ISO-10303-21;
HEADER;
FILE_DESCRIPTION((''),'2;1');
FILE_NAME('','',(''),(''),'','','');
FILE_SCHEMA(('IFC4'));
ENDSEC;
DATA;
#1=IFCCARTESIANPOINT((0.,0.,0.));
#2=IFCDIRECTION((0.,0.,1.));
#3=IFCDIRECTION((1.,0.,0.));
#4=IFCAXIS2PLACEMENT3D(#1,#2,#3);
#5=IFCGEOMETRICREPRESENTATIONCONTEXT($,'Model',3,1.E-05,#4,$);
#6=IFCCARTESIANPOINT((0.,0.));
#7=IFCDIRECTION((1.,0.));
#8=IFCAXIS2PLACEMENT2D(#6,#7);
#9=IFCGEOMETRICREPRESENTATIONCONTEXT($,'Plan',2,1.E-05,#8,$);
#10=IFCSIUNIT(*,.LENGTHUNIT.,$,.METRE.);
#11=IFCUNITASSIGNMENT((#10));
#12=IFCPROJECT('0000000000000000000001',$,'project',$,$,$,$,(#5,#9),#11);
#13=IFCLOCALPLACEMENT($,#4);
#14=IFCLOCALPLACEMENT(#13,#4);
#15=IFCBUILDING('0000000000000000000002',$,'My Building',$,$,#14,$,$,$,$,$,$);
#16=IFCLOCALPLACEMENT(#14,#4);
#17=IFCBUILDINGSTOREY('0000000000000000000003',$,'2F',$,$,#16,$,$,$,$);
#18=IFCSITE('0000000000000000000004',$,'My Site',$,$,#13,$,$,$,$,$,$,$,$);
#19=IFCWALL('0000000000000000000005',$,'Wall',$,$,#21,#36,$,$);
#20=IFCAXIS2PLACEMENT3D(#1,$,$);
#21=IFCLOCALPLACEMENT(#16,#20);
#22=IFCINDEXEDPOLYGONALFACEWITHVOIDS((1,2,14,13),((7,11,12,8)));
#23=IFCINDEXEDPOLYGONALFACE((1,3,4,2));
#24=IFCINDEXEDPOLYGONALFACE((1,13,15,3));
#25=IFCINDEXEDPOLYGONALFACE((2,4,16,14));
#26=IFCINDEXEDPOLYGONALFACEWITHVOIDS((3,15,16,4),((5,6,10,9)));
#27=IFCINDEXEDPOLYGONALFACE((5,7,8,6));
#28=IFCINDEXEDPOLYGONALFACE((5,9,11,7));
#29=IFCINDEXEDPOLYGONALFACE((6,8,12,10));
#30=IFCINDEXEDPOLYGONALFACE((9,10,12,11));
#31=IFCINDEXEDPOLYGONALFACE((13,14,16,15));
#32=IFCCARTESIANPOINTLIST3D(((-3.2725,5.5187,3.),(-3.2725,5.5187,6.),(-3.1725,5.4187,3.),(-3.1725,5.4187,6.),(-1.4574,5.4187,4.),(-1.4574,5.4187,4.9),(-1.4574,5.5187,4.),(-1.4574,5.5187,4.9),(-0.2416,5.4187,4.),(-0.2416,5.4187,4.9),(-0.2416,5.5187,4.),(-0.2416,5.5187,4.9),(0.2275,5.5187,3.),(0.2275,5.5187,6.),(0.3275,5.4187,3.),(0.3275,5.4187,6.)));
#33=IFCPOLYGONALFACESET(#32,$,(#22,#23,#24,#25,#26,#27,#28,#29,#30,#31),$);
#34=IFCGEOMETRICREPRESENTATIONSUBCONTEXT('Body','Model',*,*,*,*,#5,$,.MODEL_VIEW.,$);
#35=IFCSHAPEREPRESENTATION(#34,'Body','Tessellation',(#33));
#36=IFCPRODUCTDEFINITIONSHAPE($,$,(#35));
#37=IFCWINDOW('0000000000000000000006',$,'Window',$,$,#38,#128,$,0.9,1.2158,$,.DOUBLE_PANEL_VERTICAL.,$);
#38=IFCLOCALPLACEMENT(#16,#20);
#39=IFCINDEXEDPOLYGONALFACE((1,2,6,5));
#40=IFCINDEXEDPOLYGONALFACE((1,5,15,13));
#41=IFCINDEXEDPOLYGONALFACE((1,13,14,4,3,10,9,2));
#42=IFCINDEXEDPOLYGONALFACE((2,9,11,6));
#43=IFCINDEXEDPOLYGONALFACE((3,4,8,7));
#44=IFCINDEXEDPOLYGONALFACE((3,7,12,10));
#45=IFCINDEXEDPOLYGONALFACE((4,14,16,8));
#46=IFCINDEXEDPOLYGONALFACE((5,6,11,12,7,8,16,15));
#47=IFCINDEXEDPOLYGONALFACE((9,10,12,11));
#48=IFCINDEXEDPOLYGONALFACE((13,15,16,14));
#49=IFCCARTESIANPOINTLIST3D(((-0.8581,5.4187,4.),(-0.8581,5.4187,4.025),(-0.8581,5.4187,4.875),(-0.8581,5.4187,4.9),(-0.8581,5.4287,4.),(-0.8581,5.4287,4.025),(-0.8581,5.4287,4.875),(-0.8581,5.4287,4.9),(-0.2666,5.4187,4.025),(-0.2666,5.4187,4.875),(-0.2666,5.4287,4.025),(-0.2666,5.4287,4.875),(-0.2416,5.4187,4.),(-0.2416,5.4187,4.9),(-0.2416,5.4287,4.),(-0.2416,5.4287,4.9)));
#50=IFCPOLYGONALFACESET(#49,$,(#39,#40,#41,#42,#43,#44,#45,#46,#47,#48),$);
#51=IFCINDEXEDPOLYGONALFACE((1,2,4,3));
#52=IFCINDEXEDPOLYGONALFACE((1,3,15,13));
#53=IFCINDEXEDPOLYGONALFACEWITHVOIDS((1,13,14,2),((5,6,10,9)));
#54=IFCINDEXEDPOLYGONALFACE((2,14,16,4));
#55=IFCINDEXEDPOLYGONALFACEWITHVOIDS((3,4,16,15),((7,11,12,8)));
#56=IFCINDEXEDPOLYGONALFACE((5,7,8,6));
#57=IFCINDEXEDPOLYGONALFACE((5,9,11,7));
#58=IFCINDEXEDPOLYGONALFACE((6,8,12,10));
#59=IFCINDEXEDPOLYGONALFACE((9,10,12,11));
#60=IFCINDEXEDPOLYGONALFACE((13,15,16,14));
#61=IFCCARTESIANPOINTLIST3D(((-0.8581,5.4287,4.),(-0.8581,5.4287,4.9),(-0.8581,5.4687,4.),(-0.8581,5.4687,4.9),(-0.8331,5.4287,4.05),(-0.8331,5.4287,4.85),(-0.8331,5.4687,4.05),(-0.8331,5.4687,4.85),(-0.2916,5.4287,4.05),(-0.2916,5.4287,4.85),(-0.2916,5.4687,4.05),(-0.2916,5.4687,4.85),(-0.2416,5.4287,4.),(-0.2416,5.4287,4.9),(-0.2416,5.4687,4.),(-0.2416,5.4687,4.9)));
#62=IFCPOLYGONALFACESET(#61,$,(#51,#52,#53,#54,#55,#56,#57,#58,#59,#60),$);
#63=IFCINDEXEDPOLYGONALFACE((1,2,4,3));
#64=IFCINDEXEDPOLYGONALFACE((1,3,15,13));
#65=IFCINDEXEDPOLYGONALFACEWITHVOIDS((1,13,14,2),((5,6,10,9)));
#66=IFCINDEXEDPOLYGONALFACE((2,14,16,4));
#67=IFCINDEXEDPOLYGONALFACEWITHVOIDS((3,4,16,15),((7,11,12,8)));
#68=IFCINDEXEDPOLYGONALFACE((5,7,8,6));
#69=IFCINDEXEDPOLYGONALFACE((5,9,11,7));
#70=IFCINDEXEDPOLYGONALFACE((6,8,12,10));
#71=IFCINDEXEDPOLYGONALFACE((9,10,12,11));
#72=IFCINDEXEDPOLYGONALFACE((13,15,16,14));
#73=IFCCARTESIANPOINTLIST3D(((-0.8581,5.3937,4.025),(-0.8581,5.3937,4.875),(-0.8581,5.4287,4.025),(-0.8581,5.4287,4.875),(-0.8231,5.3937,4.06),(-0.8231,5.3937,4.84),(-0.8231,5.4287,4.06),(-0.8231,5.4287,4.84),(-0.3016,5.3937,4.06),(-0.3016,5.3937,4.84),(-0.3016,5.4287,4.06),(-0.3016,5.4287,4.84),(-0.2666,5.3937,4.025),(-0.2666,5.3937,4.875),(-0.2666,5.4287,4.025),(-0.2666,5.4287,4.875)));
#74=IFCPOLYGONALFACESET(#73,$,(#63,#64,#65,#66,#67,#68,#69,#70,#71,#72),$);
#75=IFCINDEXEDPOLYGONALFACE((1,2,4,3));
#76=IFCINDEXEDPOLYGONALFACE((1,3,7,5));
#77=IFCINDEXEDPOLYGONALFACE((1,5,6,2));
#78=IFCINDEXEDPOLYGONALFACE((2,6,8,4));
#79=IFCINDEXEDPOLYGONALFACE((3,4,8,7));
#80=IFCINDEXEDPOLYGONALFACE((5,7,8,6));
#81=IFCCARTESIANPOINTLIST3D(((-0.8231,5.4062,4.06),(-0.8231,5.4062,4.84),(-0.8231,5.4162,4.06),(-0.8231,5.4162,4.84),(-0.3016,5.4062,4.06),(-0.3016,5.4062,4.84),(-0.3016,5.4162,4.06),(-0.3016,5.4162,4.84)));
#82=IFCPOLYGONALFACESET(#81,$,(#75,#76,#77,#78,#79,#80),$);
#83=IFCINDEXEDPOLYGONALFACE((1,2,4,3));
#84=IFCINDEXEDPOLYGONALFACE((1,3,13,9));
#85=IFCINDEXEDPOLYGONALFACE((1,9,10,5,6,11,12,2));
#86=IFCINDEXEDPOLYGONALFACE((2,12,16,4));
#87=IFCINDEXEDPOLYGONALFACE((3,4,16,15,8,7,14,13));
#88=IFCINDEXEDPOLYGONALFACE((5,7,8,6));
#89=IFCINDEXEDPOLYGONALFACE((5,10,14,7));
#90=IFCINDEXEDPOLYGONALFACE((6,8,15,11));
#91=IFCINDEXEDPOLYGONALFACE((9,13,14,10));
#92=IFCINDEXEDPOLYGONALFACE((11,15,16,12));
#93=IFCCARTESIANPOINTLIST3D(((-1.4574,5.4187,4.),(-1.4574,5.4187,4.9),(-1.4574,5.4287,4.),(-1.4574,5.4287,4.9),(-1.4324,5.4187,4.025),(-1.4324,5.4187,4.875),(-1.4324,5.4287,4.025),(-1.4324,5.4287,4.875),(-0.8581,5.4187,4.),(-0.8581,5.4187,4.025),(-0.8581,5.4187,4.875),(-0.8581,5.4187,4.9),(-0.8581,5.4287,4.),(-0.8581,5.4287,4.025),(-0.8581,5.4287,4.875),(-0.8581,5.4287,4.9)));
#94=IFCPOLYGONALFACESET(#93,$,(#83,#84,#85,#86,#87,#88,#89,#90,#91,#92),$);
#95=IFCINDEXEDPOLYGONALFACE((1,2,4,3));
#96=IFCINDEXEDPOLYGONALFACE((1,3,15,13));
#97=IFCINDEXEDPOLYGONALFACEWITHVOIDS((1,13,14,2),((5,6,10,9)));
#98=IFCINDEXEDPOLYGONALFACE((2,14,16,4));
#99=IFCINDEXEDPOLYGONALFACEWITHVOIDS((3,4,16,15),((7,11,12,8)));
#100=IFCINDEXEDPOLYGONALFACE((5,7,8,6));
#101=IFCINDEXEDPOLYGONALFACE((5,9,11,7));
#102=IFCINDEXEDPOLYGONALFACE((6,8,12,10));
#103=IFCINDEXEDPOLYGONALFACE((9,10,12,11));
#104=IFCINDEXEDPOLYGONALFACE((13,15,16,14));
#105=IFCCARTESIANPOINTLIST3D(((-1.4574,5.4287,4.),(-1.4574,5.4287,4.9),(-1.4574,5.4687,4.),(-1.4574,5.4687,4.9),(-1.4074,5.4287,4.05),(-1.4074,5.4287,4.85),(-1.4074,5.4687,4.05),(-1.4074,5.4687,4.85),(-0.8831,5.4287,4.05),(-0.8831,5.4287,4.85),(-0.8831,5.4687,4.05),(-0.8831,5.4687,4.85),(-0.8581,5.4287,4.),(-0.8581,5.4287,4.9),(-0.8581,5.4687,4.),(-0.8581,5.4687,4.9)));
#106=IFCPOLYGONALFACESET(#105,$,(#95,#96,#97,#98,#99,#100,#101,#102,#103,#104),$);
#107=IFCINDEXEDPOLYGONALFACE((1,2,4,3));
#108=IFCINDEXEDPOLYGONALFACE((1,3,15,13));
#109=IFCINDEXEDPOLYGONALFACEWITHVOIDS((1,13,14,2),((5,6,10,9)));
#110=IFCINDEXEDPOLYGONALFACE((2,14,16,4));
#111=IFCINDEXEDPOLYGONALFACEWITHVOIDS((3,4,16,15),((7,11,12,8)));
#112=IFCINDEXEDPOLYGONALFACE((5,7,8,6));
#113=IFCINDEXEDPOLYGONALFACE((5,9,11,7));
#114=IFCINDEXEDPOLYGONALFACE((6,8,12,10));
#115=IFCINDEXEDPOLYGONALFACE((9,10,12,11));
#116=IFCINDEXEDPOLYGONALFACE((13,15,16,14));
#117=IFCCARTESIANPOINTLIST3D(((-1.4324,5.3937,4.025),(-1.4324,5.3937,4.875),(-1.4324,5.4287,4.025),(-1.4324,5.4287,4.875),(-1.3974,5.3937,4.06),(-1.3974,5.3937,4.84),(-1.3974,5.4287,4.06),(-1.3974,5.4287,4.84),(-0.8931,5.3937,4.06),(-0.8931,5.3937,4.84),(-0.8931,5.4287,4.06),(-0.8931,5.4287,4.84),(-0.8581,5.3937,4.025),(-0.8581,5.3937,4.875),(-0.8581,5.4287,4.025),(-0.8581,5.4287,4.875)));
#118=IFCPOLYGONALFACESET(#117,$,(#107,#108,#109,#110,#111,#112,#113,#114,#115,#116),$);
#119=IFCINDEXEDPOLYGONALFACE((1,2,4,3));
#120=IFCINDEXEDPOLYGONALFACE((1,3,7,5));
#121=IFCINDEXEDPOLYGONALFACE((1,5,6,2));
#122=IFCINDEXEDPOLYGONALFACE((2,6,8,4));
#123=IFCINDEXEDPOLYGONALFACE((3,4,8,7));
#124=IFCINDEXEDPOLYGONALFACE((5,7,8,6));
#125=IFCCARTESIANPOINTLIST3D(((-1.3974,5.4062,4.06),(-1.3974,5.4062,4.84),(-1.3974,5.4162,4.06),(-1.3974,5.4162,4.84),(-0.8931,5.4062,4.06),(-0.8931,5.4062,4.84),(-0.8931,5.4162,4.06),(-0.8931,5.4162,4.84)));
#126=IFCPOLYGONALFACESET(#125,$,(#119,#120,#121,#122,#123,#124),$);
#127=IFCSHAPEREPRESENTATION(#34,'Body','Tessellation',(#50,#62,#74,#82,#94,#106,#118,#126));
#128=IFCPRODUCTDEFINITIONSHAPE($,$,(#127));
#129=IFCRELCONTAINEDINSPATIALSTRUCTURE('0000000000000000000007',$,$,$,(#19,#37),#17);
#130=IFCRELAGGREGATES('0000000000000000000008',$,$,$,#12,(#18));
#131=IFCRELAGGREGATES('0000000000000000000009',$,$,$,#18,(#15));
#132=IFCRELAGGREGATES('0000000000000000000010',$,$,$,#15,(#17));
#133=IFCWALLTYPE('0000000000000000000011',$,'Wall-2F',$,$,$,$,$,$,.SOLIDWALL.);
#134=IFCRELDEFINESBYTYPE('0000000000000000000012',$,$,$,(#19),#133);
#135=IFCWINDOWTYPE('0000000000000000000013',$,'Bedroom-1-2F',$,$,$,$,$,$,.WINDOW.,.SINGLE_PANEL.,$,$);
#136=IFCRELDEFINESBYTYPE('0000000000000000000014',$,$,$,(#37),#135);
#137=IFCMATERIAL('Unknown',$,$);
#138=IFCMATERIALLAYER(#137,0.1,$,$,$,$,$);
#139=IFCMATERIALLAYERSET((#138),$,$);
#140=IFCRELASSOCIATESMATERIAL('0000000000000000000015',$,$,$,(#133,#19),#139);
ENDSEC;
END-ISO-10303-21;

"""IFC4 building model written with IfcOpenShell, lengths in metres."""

from ifc_helpers import new_model, entity, si_unit, frame, origin_with_axes, origin_2d_with_axis, place, context, subcontext, project, spatial, line, indexed_curve, outline, extrude, shape, source, transform, mapped, material, layer, layer_set, layer_usage, type_object, type_shapes, element, fill, save


model = new_model("IFC4")

# Units and contexts
model_context = context("Model", 3, precision=1e-05, world=origin_with_axes())
plan_context = context("Plan", 2, precision=1e-05, world=origin_2d_with_axis())
body_context_1 = subcontext(model_context, "Body", "Model", "MODEL_VIEW")
body_context_2 = subcontext(plan_context, "Body", "Plan", "PLAN_VIEW")
ifc_project = project(units=[si_unit("LENGTHUNIT", "METRE")], contexts=[model_context, plan_context])

# Site, building, storey
site_placement = place(None, origin_with_axes())
site = spatial("IfcSite", under=ifc_project, at=site_placement, Name="My Site")
building_placement = place(site_placement, origin_with_axes())
building = spatial("IfcBuilding", under=site, at=building_placement, Name="My Building")
storey_placement = place(building_placement, origin_with_axes())
storey = spatial("IfcBuildingStorey", under=building, at=storey_placement, Name="2F")

# Shared definitions
ifc_material_1 = material(Name="Unknown")

# Shared definitions
ifc_layer_1 = layer(ifc_material_1, 0.1)
ifc_layer_set_1 = layer_set([ifc_layer_1])
wall_type = type_object("IfcWallType", Name="Wall-2F", PredefinedType="SOLIDWALL", material=ifc_layer_set_1)

# Wall, opening, window
ifc_layer_usage_1 = layer_usage(ifc_layer_set_1, "AXIS2", "POSITIVE", 0.0)
wall_1_placement = place(storey_placement, frame((0.2275, 5.5187, 3.0), z_axis=(0.0, 0.0, 1.0), x_axis=(-1.0, 0.0, 0.0)))
wall_1 = element("IfcWall", 1, at=wall_1_placement, inside=storey, type_object=wall_type, material=ifc_layer_usage_1, Name="Wall", context=body_context_1, shape_type="SweptSolid", body=[
    extrude(outline(indexed_curve([(0.0, 0.0), (-0.1, 0.1), (3.4, 0.1), (3.5, 0.0)], segments=[line(1, 2, 3, 4, 1)])), origin_with_axes(), (0.0, 0.0, 1.0), 3.0),
])
shared_shape_1 = source(origin_with_axes(), body_context_1, "Body", "SweptSolid", [
    extrude(outline(indexed_curve([(0.0, 0.0), (1.2158, 0.0), (1.2158, 0.9), (0.0, 0.9)], segments=[line(1, 2, 3, 4, 1)])), frame((0.0, -0.6, 0.0), z_axis=(0.0, -1.0, 0.0), x_axis=(1.0, 0.0, 0.0)), (0.0, 0.0, -1.0), 1.2),
])
opening_1_placement = place(wall_1_placement, frame((0.4691, 0.0, 1.0), z_axis=(0.0, 0.0, 1.0), x_axis=(1.0, 0.0, 0.0)))
opening_1 = element("IfcOpeningElement", 2, at=opening_1_placement, cuts=wall_1, PredefinedType="OPENING", context=body_context_1, shape_type="MappedRepresentation", body=[
    mapped(shared_shape_1, transform((0.0, 0.0, 0.0), x_axis=(1.0, 0.0, 0.0), y_axis=(0.0, 1.0, 0.0), z_axis=(0.0, 0.0, 1.0), scale=1.0)),
])
window_type_1 = type_object("IfcWindowType", Name="Bedroom-1-2F", PartitioningType="SINGLE_PANEL", PredefinedType="WINDOW")
shared_shape_2 = source(origin_with_axes(), body_context_1, "Body", "SweptSolid", [
    extrude(outline(indexed_curve([(0.6164, 0.0), (0.0, 0.0), (0.0, 0.9), (0.6164, 0.9), (0.6164, 0.875), (0.025, 0.875), (0.025, 0.025), (0.6164, 0.025)], segments=[line(1, 2, 3, 4, 5, 6, 7, 8, 1)])), frame((0.0, 0.09, 0.0), z_axis=(0.0, -1.0, 0.0), x_axis=(1.0, 0.0, 0.0)), (0.0, 0.0, -1.0), 0.01),
    extrude(outline(indexed_curve([(0.0, 0.0), (0.6164, 0.0), (0.6164, 0.9), (0.0, 0.9)], segments=[line(1, 2, 3, 4, 1)]), holes=[indexed_curve([(0.05, 0.05), (0.5914, 0.05), (0.5914, 0.85), (0.05, 0.85)], segments=[line(1, 2, 3, 4, 1)])]), frame((0.0, 0.05, 0.0), z_axis=(0.0, -1.0, 0.0), x_axis=(1.0, 0.0, 0.0)), (0.0, 0.0, -1.0), 0.04),
    extrude(outline(indexed_curve([(0.0, 0.0), (0.5914, 0.0), (0.5914, 0.85), (0.0, 0.85)], segments=[line(1, 2, 3, 4, 1)]), holes=[indexed_curve([(0.035, 0.035), (0.5564, 0.035), (0.5564, 0.815), (0.035, 0.815)], segments=[line(1, 2, 3, 4, 1)])]), frame((0.025, 0.09, 0.025), z_axis=(0.0, -1.0, 0.0), x_axis=(1.0, 0.0, 0.0)), (0.0, 0.0, -1.0), 0.035),
    extrude(outline(indexed_curve([(0.035, 0.035), (0.5564, 0.035), (0.5564, 0.815), (0.035, 0.815)], segments=[line(1, 2, 3, 4, 1)])), frame((0.025, 0.1025, 0.025), z_axis=(0.0, -1.0, 0.0), x_axis=(1.0, 0.0, 0.0)), (0.0, 0.0, -1.0), 0.01),
    extrude(outline(indexed_curve([(0.0, 0.9), (0.5993, 0.9), (0.5993, 0.0), (0.0, 0.0), (0.0, 0.025), (0.5743, 0.025), (0.5743, 0.875), (0.0, 0.875)], segments=[line(1, 2, 3, 4, 5, 6, 7, 8, 1)])), frame((0.6164, 0.09, 0.0), z_axis=(0.0, -1.0, 0.0), x_axis=(1.0, 0.0, 0.0)), (0.0, 0.0, -1.0), 0.01),
    extrude(outline(indexed_curve([(0.0, 0.0), (0.5993, 0.0), (0.5993, 0.9), (0.0, 0.9)], segments=[line(1, 2, 3, 4, 1)]), holes=[indexed_curve([(0.025, 0.05), (0.5493, 0.05), (0.5493, 0.85), (0.025, 0.85)], segments=[line(1, 2, 3, 4, 1)])]), frame((0.6164, 0.05, 0.0), z_axis=(0.0, -1.0, 0.0), x_axis=(1.0, 0.0, 0.0)), (0.0, 0.0, -1.0), 0.04),
    extrude(outline(indexed_curve([(0.0, 0.0), (0.5743, 0.0), (0.5743, 0.85), (0.0, 0.85)], segments=[line(1, 2, 3, 4, 1)]), holes=[indexed_curve([(0.035, 0.035), (0.5393, 0.035), (0.5393, 0.815), (0.035, 0.815)], segments=[line(1, 2, 3, 4, 1)])]), frame((0.6164, 0.09, 0.025), z_axis=(0.0, -1.0, 0.0), x_axis=(1.0, 0.0, 0.0)), (0.0, 0.0, -1.0), 0.035),
    extrude(outline(indexed_curve([(0.035, 0.035), (0.5393, 0.035), (0.5393, 0.815), (0.035, 0.815)], segments=[line(1, 2, 3, 4, 1)])), frame((0.6164, 0.1025, 0.025), z_axis=(0.0, -1.0, 0.0), x_axis=(1.0, 0.0, 0.0)), (0.0, 0.0, -1.0), 0.01),
])
shared_shape_3 = source(origin_with_axes(), body_context_2, "Body", "Curve2D", [
    entity("IfcIndexedPolyCurve", entity("IfcCartesianPointList2D", [[0.05, 0.05], [0.5914, 0.05]])),
    entity("IfcIndexedPolyCurve", entity("IfcCartesianPointList2D", [[0.0, 0.1], [0.025, 0.1], [0.025, 0.09], [0.05, 0.09], [0.05, 0.05], [0.0, 0.05]]), [entity("IfcLineIndex", [1, 2, 3, 4, 5, 6, 1])]),
    entity("IfcIndexedPolyCurve", entity("IfcCartesianPointList2D", [[0.6164, 0.1], [0.6164, 0.1], [0.6164, 0.09], [0.5914, 0.09], [0.5914, 0.05], [0.6164, 0.05]])),
    entity("IfcIndexedPolyCurve", entity("IfcCartesianPointList2D", [[0.025, 0.09], [0.06, 0.09], [0.06, 0.125], [0.025, 0.125]]), [entity("IfcLineIndex", [1, 2, 3, 4, 1])]),
    entity("IfcIndexedPolyCurve", entity("IfcCartesianPointList2D", [[0.6164, 0.09], [0.5814, 0.09], [0.5814, 0.125], [0.6164, 0.125]]), [entity("IfcLineIndex", [1, 2, 3, 4, 1])]),
    entity("IfcIndexedPolyCurve", entity("IfcCartesianPointList2D", [[0.06, 0.09], [0.5814, 0.09]])),
    entity("IfcIndexedPolyCurve", entity("IfcCartesianPointList2D", [[0.06, 0.125], [0.5814, 0.125]])),
    entity("IfcIndexedPolyCurve", entity("IfcCartesianPointList2D", [[0.06, 0.1075], [0.5814, 0.1075]])),
    entity("IfcIndexedPolyCurve", entity("IfcCartesianPointList2D", [[0.6414, 0.05], [1.1658, 0.05]])),
    entity("IfcIndexedPolyCurve", entity("IfcCartesianPointList2D", [[0.6164, 0.1], [0.6164, 0.1], [0.6164, 0.09], [0.6414, 0.09], [0.6414, 0.05], [0.6164, 0.05]])),
    entity("IfcIndexedPolyCurve", entity("IfcCartesianPointList2D", [[1.2158, 0.1], [1.1908, 0.1], [1.1908, 0.09], [1.1658, 0.09], [1.1658, 0.05], [1.2158, 0.05]]), [entity("IfcLineIndex", [1, 2, 3, 4, 5, 6, 1])]),
    entity("IfcIndexedPolyCurve", entity("IfcCartesianPointList2D", [[0.6164, 0.09], [0.6514, 0.09], [0.6514, 0.125], [0.6164, 0.125]]), [entity("IfcLineIndex", [1, 2, 3, 4, 1])]),
    entity("IfcIndexedPolyCurve", entity("IfcCartesianPointList2D", [[1.1908, 0.09], [1.1558, 0.09], [1.1558, 0.125], [1.1908, 0.125]]), [entity("IfcLineIndex", [1, 2, 3, 4, 1])]),
    entity("IfcIndexedPolyCurve", entity("IfcCartesianPointList2D", [[0.6514, 0.09], [1.1558, 0.09]])),
    entity("IfcIndexedPolyCurve", entity("IfcCartesianPointList2D", [[0.6514, 0.125], [1.1558, 0.125]])),
    entity("IfcIndexedPolyCurve", entity("IfcCartesianPointList2D", [[0.6514, 0.1075], [1.1558, 0.1075]])),
])
type_shapes(window_type_1, [shared_shape_2, shared_shape_3])
window_1_placement = place(opening_1_placement, frame((0.0, 0.0, 0.0), z_axis=(0.0, 0.0, 1.0), x_axis=(1.0, 0.0, 0.0)))
window_1 = element("IfcWindow", 3, at=window_1_placement, inside=storey, type_object=window_type_1, Name="Window", OverallHeight=0.9, OverallWidth=1.2158, PartitioningType="DOUBLE_PANEL_VERTICAL", shapes=[
    shape(body_context_1, "Body", "MappedRepresentation", [mapped(shared_shape_2, transform((0.0, 0.0, 0.0), x_axis=(1.0, 0.0, 0.0), y_axis=(0.0, 1.0, 0.0), z_axis=(0.0, 0.0, 1.0), scale=1.0))]),
    shape(body_context_2, "Body", "MappedRepresentation", [mapped(shared_shape_3, transform((0.0, 0.0, 0.0), x_axis=(1.0, 0.0, 0.0), y_axis=(0.0, 1.0, 0.0), z_axis=(0.0, 0.0, 1.0), scale=1.0))]),
])
fill(opening_1, window_1)

save(model, "model.ifc")
